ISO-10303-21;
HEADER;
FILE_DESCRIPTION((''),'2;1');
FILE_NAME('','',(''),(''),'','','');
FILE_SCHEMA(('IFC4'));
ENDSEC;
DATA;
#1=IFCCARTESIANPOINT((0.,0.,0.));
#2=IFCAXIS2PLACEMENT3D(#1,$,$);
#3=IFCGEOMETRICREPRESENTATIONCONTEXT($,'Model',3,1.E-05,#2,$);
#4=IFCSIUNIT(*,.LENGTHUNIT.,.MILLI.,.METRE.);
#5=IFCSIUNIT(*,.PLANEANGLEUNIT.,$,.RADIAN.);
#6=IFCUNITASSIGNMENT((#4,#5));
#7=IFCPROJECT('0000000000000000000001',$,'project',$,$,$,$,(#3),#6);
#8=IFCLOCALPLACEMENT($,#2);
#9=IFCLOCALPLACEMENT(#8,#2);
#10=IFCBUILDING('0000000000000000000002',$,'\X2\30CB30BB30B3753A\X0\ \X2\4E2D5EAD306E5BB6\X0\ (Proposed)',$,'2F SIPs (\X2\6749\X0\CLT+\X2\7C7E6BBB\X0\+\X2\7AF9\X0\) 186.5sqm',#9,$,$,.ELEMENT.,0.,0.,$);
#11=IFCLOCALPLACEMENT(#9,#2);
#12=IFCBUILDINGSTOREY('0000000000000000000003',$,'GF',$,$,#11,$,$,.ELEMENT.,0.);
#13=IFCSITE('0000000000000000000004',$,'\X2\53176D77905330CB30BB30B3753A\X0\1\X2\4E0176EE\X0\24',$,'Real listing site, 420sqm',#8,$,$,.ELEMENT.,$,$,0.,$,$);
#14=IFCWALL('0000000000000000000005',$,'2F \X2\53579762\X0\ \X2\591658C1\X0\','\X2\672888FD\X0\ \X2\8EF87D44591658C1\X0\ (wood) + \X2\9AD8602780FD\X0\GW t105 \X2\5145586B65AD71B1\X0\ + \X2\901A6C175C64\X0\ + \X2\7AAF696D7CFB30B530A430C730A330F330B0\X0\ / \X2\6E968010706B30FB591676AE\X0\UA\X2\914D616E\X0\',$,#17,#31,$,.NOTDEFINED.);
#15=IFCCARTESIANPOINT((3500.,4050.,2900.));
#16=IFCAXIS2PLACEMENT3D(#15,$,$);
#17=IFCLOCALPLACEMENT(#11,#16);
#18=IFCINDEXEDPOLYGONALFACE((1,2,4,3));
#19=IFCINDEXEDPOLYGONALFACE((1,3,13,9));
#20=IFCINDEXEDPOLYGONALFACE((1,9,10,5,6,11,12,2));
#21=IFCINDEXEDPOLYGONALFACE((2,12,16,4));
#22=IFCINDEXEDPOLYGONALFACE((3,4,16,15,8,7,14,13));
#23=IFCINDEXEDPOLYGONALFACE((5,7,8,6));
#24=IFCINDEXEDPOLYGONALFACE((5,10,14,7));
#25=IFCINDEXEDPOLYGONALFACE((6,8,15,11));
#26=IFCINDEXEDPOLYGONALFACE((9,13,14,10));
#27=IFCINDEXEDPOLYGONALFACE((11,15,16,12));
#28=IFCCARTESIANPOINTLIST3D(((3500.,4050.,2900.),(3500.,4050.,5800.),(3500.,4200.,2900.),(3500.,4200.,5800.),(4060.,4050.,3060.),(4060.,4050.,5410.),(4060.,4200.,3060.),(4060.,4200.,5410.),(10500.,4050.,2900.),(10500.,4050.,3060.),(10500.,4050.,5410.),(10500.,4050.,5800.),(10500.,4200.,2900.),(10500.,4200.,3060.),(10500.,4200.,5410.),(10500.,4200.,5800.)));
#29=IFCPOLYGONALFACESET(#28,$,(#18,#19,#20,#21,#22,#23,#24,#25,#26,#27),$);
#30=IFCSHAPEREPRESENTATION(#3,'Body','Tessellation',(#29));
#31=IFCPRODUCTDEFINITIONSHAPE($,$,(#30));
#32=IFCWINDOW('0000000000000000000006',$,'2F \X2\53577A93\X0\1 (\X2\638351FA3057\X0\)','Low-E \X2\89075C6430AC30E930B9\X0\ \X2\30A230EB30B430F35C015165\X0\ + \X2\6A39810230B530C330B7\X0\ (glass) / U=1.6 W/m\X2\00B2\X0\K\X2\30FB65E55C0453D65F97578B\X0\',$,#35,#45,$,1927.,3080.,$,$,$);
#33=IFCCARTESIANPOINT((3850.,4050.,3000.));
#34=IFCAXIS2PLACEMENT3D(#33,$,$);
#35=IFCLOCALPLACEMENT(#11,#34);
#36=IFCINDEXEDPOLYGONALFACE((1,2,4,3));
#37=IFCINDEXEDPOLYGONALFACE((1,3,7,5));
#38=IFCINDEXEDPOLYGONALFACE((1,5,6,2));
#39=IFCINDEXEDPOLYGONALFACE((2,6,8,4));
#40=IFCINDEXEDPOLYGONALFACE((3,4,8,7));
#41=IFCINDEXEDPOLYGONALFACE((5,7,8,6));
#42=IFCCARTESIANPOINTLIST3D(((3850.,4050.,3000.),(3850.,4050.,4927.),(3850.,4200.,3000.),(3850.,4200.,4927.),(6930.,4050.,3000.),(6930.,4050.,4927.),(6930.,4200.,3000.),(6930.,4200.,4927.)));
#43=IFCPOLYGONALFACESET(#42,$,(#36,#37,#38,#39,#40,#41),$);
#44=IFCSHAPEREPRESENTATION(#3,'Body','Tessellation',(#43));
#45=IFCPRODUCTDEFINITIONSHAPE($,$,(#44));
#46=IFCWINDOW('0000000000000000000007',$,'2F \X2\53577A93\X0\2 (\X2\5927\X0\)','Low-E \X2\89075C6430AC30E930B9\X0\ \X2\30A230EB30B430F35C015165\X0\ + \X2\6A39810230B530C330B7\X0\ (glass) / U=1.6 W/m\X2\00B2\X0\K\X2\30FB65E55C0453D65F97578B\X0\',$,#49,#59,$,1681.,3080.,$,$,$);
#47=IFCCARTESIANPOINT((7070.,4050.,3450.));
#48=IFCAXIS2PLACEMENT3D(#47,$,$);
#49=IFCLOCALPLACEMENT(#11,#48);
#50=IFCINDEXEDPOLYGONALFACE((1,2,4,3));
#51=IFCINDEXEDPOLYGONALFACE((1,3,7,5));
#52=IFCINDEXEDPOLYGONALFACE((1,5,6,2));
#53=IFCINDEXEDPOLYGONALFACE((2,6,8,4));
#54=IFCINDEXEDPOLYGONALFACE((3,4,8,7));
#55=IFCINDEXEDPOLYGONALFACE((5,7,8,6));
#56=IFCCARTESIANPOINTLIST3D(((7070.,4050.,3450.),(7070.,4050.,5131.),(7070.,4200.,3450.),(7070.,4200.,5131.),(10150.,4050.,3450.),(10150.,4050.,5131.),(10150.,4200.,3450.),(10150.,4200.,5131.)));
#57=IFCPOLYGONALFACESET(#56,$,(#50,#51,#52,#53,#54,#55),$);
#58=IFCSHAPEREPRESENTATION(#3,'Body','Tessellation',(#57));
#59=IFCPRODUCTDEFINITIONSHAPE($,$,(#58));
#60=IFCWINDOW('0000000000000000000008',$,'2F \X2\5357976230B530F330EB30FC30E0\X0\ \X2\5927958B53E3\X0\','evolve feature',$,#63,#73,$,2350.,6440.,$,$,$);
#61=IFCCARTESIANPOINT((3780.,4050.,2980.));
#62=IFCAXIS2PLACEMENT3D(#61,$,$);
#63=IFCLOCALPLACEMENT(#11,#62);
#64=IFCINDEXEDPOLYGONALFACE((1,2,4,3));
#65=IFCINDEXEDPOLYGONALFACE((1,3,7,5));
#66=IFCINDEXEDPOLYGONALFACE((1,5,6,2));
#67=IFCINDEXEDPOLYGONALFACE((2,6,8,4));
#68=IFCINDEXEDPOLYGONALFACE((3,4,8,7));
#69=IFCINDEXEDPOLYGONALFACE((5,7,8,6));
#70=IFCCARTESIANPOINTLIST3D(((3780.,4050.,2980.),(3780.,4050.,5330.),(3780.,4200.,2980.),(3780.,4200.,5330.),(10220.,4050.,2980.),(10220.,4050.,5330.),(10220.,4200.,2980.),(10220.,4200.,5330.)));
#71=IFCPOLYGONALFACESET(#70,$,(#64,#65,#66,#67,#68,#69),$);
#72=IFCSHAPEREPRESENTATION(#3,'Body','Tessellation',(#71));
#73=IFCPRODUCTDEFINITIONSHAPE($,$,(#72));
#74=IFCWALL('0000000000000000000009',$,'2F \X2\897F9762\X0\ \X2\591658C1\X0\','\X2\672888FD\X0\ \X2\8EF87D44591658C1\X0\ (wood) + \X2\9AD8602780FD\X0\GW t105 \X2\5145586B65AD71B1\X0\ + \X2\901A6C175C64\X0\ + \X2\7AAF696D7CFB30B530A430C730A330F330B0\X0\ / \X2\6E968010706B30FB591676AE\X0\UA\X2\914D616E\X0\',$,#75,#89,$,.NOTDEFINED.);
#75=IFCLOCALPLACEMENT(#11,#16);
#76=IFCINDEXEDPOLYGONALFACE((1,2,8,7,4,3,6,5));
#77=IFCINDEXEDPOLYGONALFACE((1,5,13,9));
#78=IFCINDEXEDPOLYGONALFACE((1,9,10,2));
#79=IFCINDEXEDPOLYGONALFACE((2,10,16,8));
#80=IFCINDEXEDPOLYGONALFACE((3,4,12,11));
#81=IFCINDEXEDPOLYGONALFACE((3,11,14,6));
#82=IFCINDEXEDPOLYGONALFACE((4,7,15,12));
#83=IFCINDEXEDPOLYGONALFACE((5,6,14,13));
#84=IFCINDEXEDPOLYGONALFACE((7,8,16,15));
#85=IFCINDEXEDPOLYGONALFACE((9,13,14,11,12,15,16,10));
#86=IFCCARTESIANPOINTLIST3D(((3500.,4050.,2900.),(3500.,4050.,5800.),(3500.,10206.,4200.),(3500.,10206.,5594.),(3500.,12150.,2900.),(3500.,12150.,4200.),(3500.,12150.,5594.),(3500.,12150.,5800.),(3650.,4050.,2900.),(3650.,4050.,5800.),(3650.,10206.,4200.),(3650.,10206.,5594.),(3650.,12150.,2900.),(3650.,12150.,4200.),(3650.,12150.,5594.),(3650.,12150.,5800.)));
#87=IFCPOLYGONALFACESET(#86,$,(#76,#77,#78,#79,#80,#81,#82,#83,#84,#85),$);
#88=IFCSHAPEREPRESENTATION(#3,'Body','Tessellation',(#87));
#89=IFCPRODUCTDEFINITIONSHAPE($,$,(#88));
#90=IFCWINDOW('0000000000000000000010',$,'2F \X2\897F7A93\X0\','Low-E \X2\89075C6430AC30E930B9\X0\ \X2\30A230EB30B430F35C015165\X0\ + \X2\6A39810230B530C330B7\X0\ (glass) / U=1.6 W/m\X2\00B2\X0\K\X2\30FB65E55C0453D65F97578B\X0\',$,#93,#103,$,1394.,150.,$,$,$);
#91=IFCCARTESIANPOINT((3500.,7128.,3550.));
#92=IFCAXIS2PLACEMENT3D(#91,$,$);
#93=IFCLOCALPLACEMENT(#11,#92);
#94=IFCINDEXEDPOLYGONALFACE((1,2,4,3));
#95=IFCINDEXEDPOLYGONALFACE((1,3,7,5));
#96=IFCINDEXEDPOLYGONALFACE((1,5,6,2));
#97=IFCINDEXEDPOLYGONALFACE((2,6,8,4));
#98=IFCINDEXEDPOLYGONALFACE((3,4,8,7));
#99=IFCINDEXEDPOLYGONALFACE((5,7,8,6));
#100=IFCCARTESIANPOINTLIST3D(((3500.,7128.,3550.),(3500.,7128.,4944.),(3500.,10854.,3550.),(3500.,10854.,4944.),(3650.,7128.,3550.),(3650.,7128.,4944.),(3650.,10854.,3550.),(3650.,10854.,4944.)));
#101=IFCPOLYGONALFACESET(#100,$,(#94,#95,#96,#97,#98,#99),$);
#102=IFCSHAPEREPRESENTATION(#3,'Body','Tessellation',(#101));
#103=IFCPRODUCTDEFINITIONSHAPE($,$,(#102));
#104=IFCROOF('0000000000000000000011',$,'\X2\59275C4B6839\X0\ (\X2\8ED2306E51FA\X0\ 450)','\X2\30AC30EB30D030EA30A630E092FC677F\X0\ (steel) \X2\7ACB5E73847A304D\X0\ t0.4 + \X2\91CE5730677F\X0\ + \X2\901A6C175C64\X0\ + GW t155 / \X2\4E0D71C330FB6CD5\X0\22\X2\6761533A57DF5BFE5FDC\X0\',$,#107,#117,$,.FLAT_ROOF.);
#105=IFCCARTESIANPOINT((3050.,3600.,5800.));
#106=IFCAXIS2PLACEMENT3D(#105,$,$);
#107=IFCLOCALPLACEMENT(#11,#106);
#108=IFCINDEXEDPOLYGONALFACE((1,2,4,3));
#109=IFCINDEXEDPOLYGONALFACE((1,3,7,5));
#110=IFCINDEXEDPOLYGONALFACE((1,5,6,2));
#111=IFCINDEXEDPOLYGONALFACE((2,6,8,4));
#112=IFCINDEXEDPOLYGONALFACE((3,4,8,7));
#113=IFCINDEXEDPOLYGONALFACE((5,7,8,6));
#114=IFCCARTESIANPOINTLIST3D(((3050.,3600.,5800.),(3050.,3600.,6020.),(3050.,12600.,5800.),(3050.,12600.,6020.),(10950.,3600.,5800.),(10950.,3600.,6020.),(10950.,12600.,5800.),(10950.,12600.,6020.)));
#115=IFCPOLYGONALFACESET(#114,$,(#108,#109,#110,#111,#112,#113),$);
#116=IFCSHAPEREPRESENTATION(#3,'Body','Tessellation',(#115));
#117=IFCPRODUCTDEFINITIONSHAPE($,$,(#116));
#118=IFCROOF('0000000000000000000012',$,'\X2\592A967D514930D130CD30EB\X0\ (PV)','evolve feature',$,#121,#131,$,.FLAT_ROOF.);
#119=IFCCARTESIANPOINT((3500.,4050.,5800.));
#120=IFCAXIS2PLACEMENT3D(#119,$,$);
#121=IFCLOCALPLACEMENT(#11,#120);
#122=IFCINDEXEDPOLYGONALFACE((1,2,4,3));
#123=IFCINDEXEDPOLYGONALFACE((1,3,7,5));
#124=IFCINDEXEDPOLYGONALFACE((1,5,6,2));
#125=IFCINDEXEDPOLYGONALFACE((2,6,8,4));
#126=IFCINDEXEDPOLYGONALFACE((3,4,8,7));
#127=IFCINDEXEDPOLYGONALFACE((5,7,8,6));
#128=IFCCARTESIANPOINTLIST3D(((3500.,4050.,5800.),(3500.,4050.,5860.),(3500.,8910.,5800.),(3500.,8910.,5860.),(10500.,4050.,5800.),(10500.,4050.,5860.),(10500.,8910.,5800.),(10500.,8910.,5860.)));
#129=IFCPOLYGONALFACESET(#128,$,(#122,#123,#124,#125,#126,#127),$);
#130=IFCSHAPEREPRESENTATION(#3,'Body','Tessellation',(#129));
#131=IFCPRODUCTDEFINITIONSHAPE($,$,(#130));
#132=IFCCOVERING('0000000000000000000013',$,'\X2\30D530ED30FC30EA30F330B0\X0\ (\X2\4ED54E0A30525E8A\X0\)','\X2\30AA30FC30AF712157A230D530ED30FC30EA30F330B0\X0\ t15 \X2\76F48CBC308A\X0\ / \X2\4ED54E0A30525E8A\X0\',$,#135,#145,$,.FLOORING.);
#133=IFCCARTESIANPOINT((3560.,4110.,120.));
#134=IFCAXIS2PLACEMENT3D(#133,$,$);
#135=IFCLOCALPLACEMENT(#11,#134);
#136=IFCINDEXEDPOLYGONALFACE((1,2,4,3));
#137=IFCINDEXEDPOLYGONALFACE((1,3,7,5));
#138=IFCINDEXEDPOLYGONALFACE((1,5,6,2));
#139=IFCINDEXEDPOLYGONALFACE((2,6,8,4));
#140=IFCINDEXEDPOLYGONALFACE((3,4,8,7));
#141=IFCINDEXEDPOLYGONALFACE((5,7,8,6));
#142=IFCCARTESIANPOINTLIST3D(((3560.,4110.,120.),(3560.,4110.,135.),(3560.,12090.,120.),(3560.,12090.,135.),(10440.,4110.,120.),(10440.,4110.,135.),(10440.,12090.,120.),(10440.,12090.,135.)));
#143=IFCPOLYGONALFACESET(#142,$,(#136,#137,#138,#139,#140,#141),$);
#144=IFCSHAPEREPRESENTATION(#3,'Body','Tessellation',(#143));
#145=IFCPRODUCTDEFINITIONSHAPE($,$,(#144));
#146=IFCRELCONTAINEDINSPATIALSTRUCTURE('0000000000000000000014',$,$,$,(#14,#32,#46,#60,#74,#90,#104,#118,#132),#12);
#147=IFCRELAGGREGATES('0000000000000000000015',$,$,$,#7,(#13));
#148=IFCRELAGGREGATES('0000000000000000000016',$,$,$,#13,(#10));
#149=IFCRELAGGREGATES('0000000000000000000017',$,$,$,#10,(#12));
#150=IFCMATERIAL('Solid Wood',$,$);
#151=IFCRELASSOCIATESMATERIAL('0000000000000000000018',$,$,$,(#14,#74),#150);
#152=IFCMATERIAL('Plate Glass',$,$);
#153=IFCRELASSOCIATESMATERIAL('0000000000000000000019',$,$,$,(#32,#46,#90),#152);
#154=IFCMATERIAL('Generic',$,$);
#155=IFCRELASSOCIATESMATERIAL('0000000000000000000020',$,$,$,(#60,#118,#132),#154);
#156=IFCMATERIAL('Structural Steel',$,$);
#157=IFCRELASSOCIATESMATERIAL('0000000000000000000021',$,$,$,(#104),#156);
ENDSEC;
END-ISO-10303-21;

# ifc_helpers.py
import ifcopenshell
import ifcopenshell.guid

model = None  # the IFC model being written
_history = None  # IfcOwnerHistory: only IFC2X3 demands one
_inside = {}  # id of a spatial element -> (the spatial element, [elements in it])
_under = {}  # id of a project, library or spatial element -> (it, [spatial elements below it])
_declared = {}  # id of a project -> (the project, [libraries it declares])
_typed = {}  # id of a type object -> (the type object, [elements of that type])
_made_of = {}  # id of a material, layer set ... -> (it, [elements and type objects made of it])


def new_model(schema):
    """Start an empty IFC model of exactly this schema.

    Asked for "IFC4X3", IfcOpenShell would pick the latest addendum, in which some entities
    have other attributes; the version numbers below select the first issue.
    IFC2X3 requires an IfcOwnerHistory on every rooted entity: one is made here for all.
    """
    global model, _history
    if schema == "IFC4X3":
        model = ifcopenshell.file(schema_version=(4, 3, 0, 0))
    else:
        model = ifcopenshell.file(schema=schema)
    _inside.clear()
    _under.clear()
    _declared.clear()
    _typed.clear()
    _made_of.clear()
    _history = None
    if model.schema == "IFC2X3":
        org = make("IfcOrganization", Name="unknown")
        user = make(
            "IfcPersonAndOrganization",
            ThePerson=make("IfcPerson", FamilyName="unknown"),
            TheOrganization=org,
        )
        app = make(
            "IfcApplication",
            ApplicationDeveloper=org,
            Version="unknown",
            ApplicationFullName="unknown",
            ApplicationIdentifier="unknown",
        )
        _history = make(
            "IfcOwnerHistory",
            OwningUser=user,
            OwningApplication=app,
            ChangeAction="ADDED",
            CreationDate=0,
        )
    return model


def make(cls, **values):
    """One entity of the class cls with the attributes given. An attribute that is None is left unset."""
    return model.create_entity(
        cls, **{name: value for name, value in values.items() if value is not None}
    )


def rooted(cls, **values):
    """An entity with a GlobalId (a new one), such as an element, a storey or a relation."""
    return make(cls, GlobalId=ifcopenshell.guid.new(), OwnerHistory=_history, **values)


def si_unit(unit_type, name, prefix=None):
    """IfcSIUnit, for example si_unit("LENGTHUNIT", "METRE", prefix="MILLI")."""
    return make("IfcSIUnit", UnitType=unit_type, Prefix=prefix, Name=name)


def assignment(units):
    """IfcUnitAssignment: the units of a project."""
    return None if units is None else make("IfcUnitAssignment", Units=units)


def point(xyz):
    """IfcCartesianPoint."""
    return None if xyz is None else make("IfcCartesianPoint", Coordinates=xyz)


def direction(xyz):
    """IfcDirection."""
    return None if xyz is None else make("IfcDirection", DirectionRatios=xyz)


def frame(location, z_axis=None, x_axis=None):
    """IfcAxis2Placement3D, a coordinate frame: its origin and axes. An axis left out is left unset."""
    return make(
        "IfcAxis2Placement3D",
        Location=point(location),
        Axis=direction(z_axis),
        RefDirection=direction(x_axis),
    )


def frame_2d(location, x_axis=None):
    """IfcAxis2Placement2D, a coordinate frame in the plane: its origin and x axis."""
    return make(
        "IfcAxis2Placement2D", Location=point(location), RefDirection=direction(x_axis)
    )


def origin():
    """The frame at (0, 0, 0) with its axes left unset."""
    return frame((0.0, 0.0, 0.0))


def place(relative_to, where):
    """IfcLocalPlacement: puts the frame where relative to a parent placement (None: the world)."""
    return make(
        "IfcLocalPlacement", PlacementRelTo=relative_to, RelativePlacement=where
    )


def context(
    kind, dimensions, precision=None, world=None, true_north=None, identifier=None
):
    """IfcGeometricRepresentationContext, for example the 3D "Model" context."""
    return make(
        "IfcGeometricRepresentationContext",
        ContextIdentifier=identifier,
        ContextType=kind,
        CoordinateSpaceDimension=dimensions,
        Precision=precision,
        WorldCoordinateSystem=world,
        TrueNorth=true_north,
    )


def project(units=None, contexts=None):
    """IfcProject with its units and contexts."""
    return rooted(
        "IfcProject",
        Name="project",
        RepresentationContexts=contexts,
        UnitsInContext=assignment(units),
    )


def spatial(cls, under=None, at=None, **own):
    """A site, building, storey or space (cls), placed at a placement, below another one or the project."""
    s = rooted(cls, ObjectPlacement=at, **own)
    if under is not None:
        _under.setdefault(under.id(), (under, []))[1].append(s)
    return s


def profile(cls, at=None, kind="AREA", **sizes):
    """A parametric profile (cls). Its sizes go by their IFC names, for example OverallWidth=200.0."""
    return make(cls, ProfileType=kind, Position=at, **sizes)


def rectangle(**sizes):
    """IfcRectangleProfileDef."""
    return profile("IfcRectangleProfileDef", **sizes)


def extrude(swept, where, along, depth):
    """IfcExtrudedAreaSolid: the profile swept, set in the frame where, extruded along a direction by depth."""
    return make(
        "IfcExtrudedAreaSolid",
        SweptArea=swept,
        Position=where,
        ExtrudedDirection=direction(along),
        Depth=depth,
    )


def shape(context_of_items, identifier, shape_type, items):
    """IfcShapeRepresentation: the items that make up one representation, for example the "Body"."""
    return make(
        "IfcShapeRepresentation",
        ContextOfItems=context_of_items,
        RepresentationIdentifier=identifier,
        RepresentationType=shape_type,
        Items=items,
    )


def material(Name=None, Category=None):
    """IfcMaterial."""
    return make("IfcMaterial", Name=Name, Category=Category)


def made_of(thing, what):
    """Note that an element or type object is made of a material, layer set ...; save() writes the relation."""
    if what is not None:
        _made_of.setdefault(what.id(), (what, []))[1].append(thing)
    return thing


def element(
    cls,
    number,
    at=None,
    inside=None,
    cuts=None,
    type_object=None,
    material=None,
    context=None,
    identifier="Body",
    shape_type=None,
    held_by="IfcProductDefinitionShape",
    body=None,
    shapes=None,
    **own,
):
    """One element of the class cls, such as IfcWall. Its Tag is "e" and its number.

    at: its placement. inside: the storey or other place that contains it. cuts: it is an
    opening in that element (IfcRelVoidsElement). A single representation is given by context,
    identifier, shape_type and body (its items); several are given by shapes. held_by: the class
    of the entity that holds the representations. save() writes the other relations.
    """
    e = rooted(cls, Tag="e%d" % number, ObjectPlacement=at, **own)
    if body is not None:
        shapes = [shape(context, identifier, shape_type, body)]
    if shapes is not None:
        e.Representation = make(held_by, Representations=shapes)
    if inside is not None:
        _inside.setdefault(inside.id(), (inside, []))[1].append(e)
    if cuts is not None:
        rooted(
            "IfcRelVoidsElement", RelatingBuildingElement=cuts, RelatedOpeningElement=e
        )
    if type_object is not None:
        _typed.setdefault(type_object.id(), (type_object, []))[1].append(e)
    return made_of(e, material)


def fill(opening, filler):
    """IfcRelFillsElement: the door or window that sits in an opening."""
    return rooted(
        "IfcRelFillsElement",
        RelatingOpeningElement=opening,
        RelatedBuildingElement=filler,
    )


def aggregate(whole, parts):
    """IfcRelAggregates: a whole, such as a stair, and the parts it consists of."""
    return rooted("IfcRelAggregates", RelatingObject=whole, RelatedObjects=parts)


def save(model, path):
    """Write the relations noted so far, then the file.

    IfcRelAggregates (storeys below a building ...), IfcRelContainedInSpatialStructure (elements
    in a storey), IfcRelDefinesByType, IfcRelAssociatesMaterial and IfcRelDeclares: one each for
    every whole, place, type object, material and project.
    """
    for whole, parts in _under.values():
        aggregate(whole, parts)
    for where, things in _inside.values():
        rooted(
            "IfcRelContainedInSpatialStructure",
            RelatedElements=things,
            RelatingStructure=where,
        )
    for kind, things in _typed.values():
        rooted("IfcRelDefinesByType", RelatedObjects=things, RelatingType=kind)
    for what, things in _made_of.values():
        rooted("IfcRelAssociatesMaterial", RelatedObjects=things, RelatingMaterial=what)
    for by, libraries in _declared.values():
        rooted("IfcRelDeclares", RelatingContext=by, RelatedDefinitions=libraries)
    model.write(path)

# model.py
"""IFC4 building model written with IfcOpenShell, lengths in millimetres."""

from ifc_helpers import new_model, si_unit, frame, frame_2d, origin, place, context, project, spatial, rectangle, extrude, material, element, fill, save


model = new_model("IFC4")

# Units and contexts
model_context = context("Model", 3, precision=1e-05, world=origin())
ifc_project = project(units=[si_unit("LENGTHUNIT", "METRE", prefix="MILLI"), si_unit("PLANEANGLEUNIT", "RADIAN")], contexts=[model_context])

# Site, building, storey
site_placement = place(None, origin())
site = spatial("IfcSite", under=ifc_project, at=site_placement, Name="北海道ニセコ町1丁目24", ObjectType="Real listing site, 420sqm", CompositionType="ELEMENT", RefElevation=0.0)
building_placement = place(site_placement, origin())
building = spatial("IfcBuilding", under=site, at=building_placement, Name="ニセコ町 中庭の家 (Proposed)", ObjectType="2F SIPs (杉CLT+籾殻+竹) 186.5sqm", CompositionType="ELEMENT", ElevationOfRefHeight=0.0, ElevationOfTerrain=0.0)
storey_placement = place(building_placement, origin())
storey = spatial("IfcBuildingStorey", under=building, at=storey_placement, Name="GF", CompositionType="ELEMENT", Elevation=0.0)

# Shared definitions
ifc_material_1 = material(Name="Solid Wood")
ifc_material_2 = material(Name="Generic")

# Shared definitions
ifc_material_3 = material(Name="Plate Glass")

# Wall, openings, windows
wall_1_placement = place(storey_placement, frame((3500.0, 4050.0, 2900.0)))
wall_1 = element("IfcWall", 1, at=wall_1_placement, inside=storey, material=ifc_material_1, Name="2F 南面 外壁", Description="木製 軸組外壁 (wood) + 高性能GW t105 充填断熱 + 通気層 + 窯業系サイディング / 準耐火・外皮UA配慮", PredefinedType="NOTDEFINED", context=model_context, shape_type="SweptSolid", body=[
    extrude(rectangle(XDim=7000.0, YDim=150.0, at=frame_2d((3500.0, 75.0))), frame((3500.0, 4050.0, 2900.0)), (0.0, 0.0, 1.0), 2900.0),
])
opening_1_placement = place(storey_placement, frame((3850.0, 4050.0, 3000.0)))
opening_1 = element("IfcOpeningElement", 2, at=opening_1_placement, cuts=wall_1, PredefinedType="NOTDEFINED", context=model_context, shape_type="SweptSolid", body=[
    extrude(rectangle(XDim=3080.0, YDim=150.0, at=frame_2d((1540.0, 75.0))), frame((3850.0, 4050.0, 3000.0)), (0.0, 0.0, 1.0), 1927.0),
])
opening_2_placement = place(storey_placement, frame((7070.0, 4050.0, 3450.0)))
opening_2 = element("IfcOpeningElement", 3, at=opening_2_placement, cuts=wall_1, PredefinedType="NOTDEFINED", context=model_context, shape_type="SweptSolid", body=[
    extrude(rectangle(XDim=3080.0, YDim=150.0, at=frame_2d((1540.0, 75.0))), frame((7070.0, 4050.0, 3450.0)), (0.0, 0.0, 1.0), 1681.0),
])
opening_3_placement = place(storey_placement, frame((3780.0, 4050.0, 2980.0)))
opening_3 = element("IfcOpeningElement", 4, at=opening_3_placement, cuts=wall_1, PredefinedType="NOTDEFINED", context=model_context, shape_type="SweptSolid", body=[
    extrude(rectangle(XDim=6440.0, YDim=150.0, at=frame_2d((3220.0, 75.0))), frame((3780.0, 4050.0, 2980.0)), (0.0, 0.0, 1.0), 2350.0),
])
window_1_placement = place(storey_placement, frame((3850.0, 4050.0, 3000.0)))
window_1 = element("IfcWindow", 5, at=window_1_placement, inside=storey, material=ifc_material_3, Name="2F 南窓1 (掃出し)", Description="Low-E 複層ガラス アルゴン封入 + 樹脂サッシ (glass) / U=1.6 W/m²K・日射取得型", OverallHeight=1927.0, OverallWidth=3080.0, context=model_context, shape_type="SweptSolid", body=[
    extrude(rectangle(XDim=3080.0, YDim=150.0, at=frame_2d((1540.0, 75.0))), frame((3850.0, 4050.0, 3000.0)), (0.0, 0.0, 1.0), 1927.0),
])
fill(opening_1, window_1)
window_2_placement = place(storey_placement, frame((7070.0, 4050.0, 3450.0)))
window_2 = element("IfcWindow", 6, at=window_2_placement, inside=storey, material=ifc_material_3, Name="2F 南窓2 (大)", Description="Low-E 複層ガラス アルゴン封入 + 樹脂サッシ (glass) / U=1.6 W/m²K・日射取得型", OverallHeight=1681.0, OverallWidth=3080.0, context=model_context, shape_type="SweptSolid", body=[
    extrude(rectangle(XDim=3080.0, YDim=150.0, at=frame_2d((1540.0, 75.0))), frame((7070.0, 4050.0, 3450.0)), (0.0, 0.0, 1.0), 1681.0),
])
fill(opening_2, window_2)
window_3_placement = place(storey_placement, frame((3780.0, 4050.0, 2980.0)))
window_3 = element("IfcWindow", 7, at=window_3_placement, inside=storey, material=ifc_material_2, Name="2F 南面サンルーム 大開口", Description="evolve feature", OverallHeight=2350.0, OverallWidth=6440.0, context=model_context, shape_type="SweptSolid", body=[
    extrude(rectangle(XDim=6440.0, YDim=150.0, at=frame_2d((3220.0, 75.0))), frame((3780.0, 4050.0, 2980.0)), (0.0, 0.0, 1.0), 2350.0),
])
fill(opening_3, window_3)

# Wall, opening, window
wall_2_placement = place(storey_placement, frame((3500.0, 4050.0, 2900.0)))
wall_2 = element("IfcWall", 8, at=wall_2_placement, inside=storey, material=ifc_material_1, Name="2F 西面 外壁", Description="木製 軸組外壁 (wood) + 高性能GW t105 充填断熱 + 通気層 + 窯業系サイディング / 準耐火・外皮UA配慮", PredefinedType="NOTDEFINED", context=model_context, shape_type="SweptSolid", body=[
    extrude(rectangle(XDim=150.0, YDim=8100.0, at=frame_2d((75.0, 4050.0))), frame((3500.0, 4050.0, 2900.0)), (0.0, 0.0, 1.0), 2900.0),
])
opening_4_placement = place(storey_placement, frame((3500.0, 7128.0, 3550.0)))
opening_4 = element("IfcOpeningElement", 9, at=opening_4_placement, cuts=wall_2, PredefinedType="NOTDEFINED", context=model_context, shape_type="SweptSolid", body=[
    extrude(rectangle(XDim=150.0, YDim=3726.0, at=frame_2d((75.0, 1863.0))), frame((3500.0, 7128.0, 3550.0)), (0.0, 0.0, 1.0), 1394.0),
])
window_4_placement = place(storey_placement, frame((3500.0, 7128.0, 3550.0)))
window_4 = element("IfcWindow", 10, at=window_4_placement, inside=storey, material=ifc_material_3, Name="2F 西窓", Description="Low-E 複層ガラス アルゴン封入 + 樹脂サッシ (glass) / U=1.6 W/m²K・日射取得型", OverallHeight=1394.0, OverallWidth=150.0, context=model_context, shape_type="SweptSolid", body=[
    extrude(rectangle(XDim=150.0, YDim=3726.0, at=frame_2d((75.0, 1863.0))), frame((3500.0, 7128.0, 3550.0)), (0.0, 0.0, 1.0), 1394.0),
])
fill(opening_4, window_4)

# Roofs
ifc_material_4 = material(Name="Structural Steel")
roof_1_placement = place(storey_placement, frame((3050.0, 3600.0, 5800.0)))
element("IfcRoof", 11, at=roof_1_placement, inside=storey, material=ifc_material_4, Name="大屋根 (軒の出 450)", Description="ガルバリウム鋼板 (steel) 立平葺き t0.4 + 野地板 + 通気層 + GW t155 / 不燃・法22条区域対応", PredefinedType="FLAT_ROOF", context=model_context, shape_type="SweptSolid", body=[
    extrude(rectangle(XDim=7900.0, YDim=9000.0, at=frame_2d((3950.0, 4500.0))), frame((3050.0, 3600.0, 5800.0)), (0.0, 0.0, 1.0), 220.0),
])
roof_2_placement = place(storey_placement, frame((3500.0, 4050.0, 5800.0)))
element("IfcRoof", 12, at=roof_2_placement, inside=storey, material=ifc_material_2, Name="太陽光パネル (PV)", Description="evolve feature", PredefinedType="FLAT_ROOF", context=model_context, shape_type="SweptSolid", body=[
    extrude(rectangle(XDim=7000.0, YDim=4860.0, at=frame_2d((3500.0, 2430.0))), frame((3500.0, 4050.0, 5800.0)), (0.0, 0.0, 1.0), 60.0),
])

# Covering
covering_placement = place(storey_placement, frame((3560.0, 4110.0, 120.0)))
element("IfcCovering", 13, at=covering_placement, inside=storey, material=ifc_material_2, Name="フローリング (仕上げ床)", Description="オーク無垢フローリング t15 直貼り / 仕上げ床", PredefinedType="FLOORING", context=model_context, shape_type="SweptSolid", body=[
    extrude(rectangle(XDim=6880.0, YDim=7980.0, at=frame_2d((3440.0, 3990.0))), frame((3560.0, 4110.0, 120.0)), (0.0, 0.0, 1.0), 15.0),
])

save(model, "model.ifc")
